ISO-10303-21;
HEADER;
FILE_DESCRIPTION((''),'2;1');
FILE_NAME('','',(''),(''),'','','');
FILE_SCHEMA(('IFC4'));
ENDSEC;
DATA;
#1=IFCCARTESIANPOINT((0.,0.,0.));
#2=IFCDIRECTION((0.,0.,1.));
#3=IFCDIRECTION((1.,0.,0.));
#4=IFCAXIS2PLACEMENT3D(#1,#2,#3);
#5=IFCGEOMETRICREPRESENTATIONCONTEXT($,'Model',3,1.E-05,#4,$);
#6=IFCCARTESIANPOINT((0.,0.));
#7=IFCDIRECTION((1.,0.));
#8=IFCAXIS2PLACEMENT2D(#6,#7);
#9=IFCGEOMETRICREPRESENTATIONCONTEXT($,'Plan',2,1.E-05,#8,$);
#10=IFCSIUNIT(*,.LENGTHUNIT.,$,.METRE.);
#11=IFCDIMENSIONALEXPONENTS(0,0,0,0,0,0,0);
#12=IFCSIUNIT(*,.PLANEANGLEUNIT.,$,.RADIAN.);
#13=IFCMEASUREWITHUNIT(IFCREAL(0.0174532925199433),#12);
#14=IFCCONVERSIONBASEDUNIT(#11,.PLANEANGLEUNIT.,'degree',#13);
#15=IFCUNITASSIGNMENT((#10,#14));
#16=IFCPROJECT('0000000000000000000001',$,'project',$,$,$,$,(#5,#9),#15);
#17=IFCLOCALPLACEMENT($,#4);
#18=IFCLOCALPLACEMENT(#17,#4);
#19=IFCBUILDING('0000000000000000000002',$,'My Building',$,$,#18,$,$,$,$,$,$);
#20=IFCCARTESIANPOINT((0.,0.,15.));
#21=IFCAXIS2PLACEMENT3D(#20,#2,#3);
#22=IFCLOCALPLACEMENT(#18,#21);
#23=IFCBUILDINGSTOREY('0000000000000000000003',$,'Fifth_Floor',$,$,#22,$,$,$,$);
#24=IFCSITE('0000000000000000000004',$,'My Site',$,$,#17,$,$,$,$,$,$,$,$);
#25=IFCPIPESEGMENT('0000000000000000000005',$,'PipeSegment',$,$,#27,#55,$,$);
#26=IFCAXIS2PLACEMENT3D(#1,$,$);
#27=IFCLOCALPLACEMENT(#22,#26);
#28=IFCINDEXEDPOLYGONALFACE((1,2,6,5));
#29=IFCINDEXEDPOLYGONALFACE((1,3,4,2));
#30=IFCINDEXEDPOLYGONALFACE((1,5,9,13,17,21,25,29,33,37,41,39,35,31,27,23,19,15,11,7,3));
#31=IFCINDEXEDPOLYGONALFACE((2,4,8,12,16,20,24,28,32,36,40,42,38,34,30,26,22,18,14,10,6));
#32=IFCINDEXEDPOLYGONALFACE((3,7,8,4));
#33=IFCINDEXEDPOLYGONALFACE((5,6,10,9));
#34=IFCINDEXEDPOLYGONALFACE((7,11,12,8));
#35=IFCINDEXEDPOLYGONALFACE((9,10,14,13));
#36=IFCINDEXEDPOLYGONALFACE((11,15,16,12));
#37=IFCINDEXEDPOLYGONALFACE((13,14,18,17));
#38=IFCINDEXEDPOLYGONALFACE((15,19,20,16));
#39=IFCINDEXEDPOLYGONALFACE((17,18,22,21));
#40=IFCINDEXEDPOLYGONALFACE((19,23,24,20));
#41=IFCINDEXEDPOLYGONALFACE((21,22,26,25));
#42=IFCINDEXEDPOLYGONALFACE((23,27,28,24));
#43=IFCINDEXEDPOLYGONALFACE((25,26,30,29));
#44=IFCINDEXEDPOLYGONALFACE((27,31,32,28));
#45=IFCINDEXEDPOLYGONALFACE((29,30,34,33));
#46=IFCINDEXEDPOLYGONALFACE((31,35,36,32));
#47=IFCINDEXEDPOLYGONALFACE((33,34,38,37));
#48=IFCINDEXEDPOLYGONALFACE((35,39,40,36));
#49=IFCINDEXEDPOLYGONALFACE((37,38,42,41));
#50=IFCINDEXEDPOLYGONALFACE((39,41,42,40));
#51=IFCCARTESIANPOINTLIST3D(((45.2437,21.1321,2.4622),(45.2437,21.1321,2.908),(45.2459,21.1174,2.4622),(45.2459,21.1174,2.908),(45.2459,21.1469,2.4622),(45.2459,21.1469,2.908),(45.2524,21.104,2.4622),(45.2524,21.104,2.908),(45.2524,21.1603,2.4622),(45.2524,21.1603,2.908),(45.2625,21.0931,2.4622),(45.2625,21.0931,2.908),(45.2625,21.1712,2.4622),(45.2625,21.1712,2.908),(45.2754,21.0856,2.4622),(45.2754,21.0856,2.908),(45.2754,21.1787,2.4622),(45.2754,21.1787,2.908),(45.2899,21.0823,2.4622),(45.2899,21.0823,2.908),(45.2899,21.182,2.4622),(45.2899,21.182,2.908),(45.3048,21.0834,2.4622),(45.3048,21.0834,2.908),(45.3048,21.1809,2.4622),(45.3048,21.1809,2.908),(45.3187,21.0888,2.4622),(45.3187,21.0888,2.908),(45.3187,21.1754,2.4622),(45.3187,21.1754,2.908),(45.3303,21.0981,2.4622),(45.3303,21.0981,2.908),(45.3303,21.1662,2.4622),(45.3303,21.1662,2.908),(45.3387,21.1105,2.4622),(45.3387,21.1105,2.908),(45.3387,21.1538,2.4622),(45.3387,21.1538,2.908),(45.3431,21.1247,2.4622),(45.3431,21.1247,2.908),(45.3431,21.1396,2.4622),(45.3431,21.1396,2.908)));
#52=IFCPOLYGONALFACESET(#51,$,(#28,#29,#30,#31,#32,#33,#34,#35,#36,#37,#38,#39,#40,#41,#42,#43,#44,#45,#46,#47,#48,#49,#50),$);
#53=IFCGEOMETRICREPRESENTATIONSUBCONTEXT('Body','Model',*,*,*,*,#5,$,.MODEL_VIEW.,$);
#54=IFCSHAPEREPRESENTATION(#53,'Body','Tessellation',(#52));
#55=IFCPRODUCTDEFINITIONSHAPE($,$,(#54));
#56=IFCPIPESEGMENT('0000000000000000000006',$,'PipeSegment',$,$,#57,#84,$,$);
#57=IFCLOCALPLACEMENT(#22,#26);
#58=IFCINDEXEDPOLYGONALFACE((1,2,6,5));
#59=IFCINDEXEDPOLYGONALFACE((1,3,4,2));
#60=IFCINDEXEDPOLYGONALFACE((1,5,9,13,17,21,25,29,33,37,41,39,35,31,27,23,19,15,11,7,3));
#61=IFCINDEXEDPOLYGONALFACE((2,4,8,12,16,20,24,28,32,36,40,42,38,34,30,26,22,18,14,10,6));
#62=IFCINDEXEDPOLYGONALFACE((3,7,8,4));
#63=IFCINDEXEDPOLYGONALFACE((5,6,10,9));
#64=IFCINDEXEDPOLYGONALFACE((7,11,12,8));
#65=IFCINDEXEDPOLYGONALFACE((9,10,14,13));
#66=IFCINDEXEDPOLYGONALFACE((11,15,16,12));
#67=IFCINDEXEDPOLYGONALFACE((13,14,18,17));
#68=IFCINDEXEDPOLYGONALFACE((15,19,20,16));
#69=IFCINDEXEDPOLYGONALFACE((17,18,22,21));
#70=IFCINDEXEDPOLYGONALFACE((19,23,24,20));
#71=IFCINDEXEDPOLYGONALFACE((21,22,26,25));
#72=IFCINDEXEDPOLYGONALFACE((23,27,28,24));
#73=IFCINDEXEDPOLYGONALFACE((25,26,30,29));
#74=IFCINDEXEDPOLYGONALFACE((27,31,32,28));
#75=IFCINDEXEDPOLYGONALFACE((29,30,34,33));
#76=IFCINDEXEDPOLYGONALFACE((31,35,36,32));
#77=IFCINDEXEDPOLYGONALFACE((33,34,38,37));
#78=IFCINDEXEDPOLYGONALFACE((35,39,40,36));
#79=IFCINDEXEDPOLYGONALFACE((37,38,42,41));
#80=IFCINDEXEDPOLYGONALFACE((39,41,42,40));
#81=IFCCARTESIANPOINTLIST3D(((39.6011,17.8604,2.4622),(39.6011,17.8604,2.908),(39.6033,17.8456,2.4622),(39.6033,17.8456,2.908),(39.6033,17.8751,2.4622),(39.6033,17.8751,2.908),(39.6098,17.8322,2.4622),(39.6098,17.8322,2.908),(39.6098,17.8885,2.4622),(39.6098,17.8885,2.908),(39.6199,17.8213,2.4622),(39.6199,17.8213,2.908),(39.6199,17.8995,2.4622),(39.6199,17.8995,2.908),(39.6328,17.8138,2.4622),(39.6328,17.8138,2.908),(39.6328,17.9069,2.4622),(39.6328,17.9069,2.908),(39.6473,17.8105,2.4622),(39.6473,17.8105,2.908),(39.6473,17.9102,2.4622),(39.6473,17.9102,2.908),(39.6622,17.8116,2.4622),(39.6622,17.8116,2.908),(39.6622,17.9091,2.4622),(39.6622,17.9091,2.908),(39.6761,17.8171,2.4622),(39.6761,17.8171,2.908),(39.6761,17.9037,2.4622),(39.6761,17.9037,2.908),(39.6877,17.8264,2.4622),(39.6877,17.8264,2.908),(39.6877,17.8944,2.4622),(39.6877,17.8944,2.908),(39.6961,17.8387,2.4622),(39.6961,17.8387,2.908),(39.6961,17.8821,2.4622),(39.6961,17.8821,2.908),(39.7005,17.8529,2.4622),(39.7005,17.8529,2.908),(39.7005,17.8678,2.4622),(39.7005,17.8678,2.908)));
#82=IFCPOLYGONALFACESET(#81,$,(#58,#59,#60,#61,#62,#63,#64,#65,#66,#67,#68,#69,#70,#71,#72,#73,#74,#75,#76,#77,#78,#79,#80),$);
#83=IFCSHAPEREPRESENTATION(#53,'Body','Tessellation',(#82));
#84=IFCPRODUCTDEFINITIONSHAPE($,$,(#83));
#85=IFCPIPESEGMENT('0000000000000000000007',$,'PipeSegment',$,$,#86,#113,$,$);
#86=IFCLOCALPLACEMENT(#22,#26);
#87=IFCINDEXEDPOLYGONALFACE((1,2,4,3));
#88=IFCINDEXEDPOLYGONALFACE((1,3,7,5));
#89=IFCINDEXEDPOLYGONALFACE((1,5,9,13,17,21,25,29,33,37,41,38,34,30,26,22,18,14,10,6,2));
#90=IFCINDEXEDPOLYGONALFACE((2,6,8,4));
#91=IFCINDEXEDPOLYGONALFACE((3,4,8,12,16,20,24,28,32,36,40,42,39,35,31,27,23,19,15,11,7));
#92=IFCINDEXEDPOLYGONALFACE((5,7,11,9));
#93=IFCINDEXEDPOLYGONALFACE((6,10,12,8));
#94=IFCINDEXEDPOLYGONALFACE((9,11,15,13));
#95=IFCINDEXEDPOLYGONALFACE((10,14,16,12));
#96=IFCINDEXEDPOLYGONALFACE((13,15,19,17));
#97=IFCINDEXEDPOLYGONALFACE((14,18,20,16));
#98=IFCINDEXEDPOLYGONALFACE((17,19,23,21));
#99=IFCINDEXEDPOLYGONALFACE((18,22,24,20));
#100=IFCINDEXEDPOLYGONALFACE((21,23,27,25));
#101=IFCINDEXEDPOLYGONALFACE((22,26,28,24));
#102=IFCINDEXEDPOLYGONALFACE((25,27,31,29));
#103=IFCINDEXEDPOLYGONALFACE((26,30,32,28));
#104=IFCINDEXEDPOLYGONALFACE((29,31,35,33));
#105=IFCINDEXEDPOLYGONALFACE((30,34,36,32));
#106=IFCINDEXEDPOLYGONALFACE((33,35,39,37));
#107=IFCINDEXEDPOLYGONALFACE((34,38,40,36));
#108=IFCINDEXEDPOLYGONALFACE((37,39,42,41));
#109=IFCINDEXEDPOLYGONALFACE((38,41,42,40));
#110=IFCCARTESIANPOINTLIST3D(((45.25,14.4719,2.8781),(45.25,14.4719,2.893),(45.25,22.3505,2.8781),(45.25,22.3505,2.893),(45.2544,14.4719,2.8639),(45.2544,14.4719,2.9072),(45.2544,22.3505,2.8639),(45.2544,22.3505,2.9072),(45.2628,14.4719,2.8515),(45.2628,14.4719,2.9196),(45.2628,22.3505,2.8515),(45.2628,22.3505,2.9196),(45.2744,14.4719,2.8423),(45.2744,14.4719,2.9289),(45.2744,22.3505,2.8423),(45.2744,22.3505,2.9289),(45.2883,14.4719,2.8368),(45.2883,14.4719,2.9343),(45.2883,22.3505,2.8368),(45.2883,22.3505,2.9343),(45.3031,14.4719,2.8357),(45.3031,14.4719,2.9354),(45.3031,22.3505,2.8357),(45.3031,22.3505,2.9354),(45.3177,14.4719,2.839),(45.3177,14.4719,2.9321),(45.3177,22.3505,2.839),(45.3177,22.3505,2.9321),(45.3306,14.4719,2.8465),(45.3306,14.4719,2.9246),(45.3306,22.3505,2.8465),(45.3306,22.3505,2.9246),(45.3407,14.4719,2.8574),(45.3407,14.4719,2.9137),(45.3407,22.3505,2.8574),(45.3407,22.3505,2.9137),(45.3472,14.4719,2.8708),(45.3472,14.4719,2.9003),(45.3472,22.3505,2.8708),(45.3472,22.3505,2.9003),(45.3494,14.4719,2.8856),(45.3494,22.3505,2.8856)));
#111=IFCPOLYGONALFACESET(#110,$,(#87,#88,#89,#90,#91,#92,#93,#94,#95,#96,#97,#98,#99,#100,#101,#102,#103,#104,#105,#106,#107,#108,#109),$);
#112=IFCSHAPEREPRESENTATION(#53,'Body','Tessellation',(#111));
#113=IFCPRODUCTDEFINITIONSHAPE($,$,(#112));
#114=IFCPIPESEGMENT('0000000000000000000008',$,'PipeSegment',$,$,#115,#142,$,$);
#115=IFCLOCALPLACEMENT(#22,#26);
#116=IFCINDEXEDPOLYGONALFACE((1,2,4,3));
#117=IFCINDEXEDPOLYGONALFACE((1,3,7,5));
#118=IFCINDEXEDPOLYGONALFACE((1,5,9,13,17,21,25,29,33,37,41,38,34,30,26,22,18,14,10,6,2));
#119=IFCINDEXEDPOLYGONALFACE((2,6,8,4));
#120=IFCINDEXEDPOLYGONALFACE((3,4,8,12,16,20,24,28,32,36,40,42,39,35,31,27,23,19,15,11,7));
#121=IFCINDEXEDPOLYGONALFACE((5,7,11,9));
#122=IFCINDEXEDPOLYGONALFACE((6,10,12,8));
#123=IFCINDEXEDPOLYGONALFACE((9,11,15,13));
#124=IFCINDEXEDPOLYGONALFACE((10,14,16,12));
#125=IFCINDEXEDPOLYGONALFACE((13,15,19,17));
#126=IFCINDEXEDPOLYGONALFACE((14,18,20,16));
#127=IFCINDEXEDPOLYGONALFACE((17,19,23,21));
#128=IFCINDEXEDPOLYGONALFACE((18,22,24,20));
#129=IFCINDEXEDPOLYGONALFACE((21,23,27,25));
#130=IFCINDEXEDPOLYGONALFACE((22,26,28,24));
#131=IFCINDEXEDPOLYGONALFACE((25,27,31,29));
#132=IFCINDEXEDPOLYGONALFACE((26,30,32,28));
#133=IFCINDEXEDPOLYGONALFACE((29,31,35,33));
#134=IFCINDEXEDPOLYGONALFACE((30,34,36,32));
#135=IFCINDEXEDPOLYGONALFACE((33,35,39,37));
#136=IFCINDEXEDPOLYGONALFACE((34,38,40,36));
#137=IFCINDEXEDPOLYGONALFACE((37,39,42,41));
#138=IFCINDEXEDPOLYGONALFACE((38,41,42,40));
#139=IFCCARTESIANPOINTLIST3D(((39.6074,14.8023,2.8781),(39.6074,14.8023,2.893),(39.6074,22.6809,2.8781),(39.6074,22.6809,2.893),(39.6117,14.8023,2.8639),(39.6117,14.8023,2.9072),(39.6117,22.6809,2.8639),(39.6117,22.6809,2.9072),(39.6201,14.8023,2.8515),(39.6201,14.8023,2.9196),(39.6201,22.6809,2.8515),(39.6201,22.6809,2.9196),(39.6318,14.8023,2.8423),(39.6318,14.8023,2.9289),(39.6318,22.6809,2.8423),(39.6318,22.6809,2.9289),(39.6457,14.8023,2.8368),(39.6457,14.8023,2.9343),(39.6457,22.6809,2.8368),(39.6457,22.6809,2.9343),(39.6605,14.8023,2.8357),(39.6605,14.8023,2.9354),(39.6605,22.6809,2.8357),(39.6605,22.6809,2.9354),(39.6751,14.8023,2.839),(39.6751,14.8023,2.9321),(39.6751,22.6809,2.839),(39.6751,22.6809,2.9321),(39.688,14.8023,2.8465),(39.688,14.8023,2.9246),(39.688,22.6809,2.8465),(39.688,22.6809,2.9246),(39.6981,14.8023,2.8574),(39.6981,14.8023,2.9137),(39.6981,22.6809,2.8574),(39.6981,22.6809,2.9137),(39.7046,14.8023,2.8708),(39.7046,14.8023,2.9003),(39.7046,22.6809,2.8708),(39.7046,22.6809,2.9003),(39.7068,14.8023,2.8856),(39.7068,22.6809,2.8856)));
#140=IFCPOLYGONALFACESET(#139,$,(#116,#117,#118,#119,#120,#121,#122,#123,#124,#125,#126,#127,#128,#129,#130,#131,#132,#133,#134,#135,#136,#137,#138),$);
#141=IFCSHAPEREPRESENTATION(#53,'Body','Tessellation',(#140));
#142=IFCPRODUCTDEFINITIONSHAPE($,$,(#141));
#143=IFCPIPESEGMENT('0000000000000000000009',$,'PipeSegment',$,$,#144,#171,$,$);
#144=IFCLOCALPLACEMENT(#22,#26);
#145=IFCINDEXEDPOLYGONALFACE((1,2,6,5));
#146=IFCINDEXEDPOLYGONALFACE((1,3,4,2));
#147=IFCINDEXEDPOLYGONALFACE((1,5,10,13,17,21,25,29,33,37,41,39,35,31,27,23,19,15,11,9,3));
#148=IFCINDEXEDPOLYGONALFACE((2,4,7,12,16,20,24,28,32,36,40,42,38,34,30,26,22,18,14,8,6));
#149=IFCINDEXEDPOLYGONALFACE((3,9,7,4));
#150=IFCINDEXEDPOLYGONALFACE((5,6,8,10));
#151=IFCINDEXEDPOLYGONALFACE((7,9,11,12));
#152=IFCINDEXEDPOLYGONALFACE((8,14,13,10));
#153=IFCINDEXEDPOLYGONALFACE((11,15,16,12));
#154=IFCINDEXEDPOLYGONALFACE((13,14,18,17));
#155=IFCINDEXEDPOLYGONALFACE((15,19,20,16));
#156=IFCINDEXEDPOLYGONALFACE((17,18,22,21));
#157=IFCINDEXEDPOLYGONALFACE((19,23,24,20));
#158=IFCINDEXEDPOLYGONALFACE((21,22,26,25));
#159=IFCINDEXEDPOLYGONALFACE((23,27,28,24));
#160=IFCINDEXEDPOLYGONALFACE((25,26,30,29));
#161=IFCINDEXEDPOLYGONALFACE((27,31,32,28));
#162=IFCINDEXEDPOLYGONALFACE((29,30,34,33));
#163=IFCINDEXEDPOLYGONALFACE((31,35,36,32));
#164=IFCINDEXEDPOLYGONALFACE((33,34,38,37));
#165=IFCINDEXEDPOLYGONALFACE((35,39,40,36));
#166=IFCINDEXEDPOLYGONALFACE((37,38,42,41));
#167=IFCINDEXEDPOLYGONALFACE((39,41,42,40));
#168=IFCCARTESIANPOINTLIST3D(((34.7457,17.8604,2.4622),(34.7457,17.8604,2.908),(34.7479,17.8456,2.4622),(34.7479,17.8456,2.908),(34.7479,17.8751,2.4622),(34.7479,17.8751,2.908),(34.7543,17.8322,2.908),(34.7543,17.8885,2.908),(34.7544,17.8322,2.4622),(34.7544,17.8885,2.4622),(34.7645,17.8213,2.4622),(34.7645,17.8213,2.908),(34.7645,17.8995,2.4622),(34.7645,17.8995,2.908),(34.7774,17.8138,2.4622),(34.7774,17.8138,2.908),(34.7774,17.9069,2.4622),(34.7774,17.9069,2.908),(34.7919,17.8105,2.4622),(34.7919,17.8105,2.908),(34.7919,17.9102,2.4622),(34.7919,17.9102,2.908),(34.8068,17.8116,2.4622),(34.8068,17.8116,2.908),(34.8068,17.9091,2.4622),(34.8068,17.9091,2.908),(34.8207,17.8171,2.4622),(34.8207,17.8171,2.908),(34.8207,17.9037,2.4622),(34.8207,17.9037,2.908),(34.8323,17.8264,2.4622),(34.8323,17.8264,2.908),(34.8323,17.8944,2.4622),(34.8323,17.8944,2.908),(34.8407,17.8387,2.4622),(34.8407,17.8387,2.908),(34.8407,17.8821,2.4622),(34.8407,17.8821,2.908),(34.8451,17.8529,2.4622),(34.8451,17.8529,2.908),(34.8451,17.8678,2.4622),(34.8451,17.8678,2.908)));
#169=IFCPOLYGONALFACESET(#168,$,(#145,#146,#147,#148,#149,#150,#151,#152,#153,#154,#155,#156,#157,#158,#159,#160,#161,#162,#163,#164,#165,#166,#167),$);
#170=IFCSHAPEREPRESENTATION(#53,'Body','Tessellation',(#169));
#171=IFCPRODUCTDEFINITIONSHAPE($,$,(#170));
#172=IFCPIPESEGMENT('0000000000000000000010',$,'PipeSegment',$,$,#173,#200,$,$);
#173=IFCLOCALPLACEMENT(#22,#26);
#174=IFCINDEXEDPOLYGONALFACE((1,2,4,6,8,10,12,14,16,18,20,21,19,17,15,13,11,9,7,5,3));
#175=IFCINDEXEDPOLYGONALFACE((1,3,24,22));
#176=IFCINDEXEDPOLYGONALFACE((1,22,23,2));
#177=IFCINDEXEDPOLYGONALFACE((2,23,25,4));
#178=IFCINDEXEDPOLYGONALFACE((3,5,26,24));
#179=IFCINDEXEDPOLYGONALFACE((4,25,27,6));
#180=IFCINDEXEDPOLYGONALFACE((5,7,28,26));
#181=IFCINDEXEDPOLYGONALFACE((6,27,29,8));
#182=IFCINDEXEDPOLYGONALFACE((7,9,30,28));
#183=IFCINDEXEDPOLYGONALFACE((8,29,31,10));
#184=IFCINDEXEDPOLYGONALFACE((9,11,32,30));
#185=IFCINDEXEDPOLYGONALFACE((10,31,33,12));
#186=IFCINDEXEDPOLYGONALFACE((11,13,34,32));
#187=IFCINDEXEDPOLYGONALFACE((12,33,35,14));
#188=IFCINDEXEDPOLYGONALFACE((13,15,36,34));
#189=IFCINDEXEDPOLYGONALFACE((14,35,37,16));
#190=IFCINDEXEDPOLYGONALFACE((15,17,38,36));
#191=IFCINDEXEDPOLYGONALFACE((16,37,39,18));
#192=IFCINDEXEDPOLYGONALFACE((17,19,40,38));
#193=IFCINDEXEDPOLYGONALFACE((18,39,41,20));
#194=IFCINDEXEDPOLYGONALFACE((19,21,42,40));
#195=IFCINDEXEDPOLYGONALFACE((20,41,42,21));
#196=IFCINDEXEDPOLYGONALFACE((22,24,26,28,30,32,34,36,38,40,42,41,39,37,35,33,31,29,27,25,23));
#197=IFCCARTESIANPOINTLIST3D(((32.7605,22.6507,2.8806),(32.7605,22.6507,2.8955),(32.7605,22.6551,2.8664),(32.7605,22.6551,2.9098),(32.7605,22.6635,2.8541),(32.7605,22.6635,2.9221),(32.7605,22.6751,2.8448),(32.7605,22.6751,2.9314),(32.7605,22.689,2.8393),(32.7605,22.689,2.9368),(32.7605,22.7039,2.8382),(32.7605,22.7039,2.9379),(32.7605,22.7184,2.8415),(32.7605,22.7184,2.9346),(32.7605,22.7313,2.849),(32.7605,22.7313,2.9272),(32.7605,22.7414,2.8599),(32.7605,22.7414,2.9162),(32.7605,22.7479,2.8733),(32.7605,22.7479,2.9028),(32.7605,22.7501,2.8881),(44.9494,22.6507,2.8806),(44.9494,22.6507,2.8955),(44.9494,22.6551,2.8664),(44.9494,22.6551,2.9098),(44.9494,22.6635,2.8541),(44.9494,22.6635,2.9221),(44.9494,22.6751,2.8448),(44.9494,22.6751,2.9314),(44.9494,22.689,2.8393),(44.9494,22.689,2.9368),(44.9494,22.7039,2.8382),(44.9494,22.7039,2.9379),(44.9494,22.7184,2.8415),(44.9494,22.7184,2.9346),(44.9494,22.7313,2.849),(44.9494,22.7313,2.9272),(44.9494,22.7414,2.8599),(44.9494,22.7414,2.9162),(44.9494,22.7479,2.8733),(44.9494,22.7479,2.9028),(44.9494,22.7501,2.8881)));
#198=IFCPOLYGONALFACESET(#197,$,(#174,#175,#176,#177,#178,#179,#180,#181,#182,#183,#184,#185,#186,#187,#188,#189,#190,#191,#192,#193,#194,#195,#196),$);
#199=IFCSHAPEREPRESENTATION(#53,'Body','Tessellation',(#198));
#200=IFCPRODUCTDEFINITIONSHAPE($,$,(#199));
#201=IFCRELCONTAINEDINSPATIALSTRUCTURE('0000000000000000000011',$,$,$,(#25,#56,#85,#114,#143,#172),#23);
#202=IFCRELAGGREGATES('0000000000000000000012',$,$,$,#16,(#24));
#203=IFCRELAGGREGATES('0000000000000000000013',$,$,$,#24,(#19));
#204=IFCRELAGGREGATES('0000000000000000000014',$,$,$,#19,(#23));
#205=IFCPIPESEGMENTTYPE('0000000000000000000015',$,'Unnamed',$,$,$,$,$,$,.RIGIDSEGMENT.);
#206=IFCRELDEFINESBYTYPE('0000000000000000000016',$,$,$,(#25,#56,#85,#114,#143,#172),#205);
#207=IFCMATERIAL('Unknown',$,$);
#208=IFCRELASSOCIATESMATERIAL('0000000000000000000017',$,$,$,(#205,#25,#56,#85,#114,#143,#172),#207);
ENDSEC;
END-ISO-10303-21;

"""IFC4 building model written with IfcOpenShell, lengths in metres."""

from ifc_helpers import new_model, entity, si_unit, converted_unit, frame, origin_with_axes, origin_2d_with_axis, place, context, subcontext, project, spatial, circle, extrude, material, material_profile, profile_set, profile_usage, type_object, element, save


model = new_model("IFC4")

# Units and contexts
model_context = context("Model", 3, precision=1e-05, world=origin_with_axes())
plan_context = context("Plan", 2, precision=1e-05, world=origin_2d_with_axis())
body_context_1 = subcontext(model_context, "Body", "Model", "MODEL_VIEW")
ifc_project = project(units=[si_unit("LENGTHUNIT", "METRE"), converted_unit("PLANEANGLEUNIT", "degree", entity("IfcReal", 0.0174532925199433), si_unit("PLANEANGLEUNIT", "RADIAN"), dimensions=[0, 0, 0, 0, 0, 0, 0])], contexts=[model_context, plan_context])

# Site, building, storey
site_placement = place(None, origin_with_axes())
site = spatial("IfcSite", under=ifc_project, at=site_placement, Name="My Site")
building_placement = place(site_placement, origin_with_axes())
building = spatial("IfcBuilding", under=site, at=building_placement, Name="My Building")
storey_placement = place(building_placement, frame((0.0, 0.0, 15.0), z_axis=(0.0, 0.0, 1.0), x_axis=(1.0, 0.0, 0.0)))
storey = spatial("IfcBuildingStorey", under=building, at=storey_placement, Name="Fifth_Floor")

# Shared definitions
ifc_material = material(Name="Unknown")

# Pipe segments
ifc_material_profile_1 = material_profile(ifc_material, circle(Radius=0.05))
ifc_profile_set_1 = profile_set([ifc_material_profile_1])
pipe_segment_type = type_object("IfcPipeSegmentType", Name="Unnamed", PredefinedType="RIGIDSEGMENT", material=ifc_profile_set_1)
ifc_profile_usage_1 = profile_usage(ifc_profile_set_1, cardinal=5)
pipe_segment_1_placement = place(storey_placement, frame((45.2937, 21.1321, 2.908), z_axis=(0.0, 0.0, -1.0), x_axis=(-1.0, 0.0, 0.0)))
element("IfcPipeSegment", 1, at=pipe_segment_1_placement, inside=storey, type_object=pipe_segment_type, material=ifc_profile_usage_1, Name="PipeSegment", context=body_context_1, shape_type="SweptSolid", body=[
    extrude(circle(Radius=0.05), origin_with_axes(), (0.0, 0.0, 1.0), 0.4458),
])
ifc_profile_usage_2 = profile_usage(ifc_profile_set_1, cardinal=5)
pipe_segment_2_placement = place(storey_placement, frame((39.6511, 17.8604, 2.908), z_axis=(0.0, 0.0, -1.0), x_axis=(-1.0, 0.0, 0.0)))
element("IfcPipeSegment", 2, at=pipe_segment_2_placement, inside=storey, type_object=pipe_segment_type, material=ifc_profile_usage_2, Name="PipeSegment", context=body_context_1, shape_type="SweptSolid", body=[
    extrude(circle(Radius=0.05), origin_with_axes(), (0.0, 0.0, 1.0), 0.4458),
])
ifc_profile_usage_3 = profile_usage(ifc_profile_set_1, cardinal=5)
pipe_segment_3_placement = place(storey_placement, frame((45.2994, 22.3505, 2.8856), z_axis=(0.0, -1.0, 0.0), x_axis=(1.0, 0.0, 0.0)))
element("IfcPipeSegment", 3, at=pipe_segment_3_placement, inside=storey, type_object=pipe_segment_type, material=ifc_profile_usage_3, Name="PipeSegment", context=body_context_1, shape_type="SweptSolid", body=[
    extrude(circle(Radius=0.05), origin_with_axes(), (0.0, 0.0, 1.0), 7.8786),
])
ifc_profile_usage_4 = profile_usage(ifc_profile_set_1, cardinal=5)
pipe_segment_4_placement = place(storey_placement, frame((39.6568, 22.6809, 2.8856), z_axis=(0.0, -1.0, 0.0), x_axis=(1.0, 0.0, 0.0)))
element("IfcPipeSegment", 4, at=pipe_segment_4_placement, inside=storey, type_object=pipe_segment_type, material=ifc_profile_usage_4, Name="PipeSegment", context=body_context_1, shape_type="SweptSolid", body=[
    extrude(circle(Radius=0.05), origin_with_axes(), (0.0, 0.0, 1.0), 7.8786),
])
ifc_profile_usage_5 = profile_usage(ifc_profile_set_1, cardinal=5)
pipe_segment_5_placement = place(storey_placement, frame((34.7957, 17.8604, 2.908), z_axis=(0.0, 0.0, -1.0), x_axis=(-1.0, 0.0, 0.0)))
element("IfcPipeSegment", 5, at=pipe_segment_5_placement, inside=storey, type_object=pipe_segment_type, material=ifc_profile_usage_5, Name="PipeSegment", context=body_context_1, shape_type="SweptSolid", body=[
    extrude(circle(Radius=0.05), origin_with_axes(), (0.0, 0.0, 1.0), 0.4458),
])
ifc_profile_usage_6 = profile_usage(ifc_profile_set_1, cardinal=6)
pipe_segment_6_placement = place(storey_placement, frame((32.7605, 22.6501, 2.8881), z_axis=(1.0, 0.0, 0.000001), x_axis=(0.0, 1.0, 0.0)))
element("IfcPipeSegment", 6, at=pipe_segment_6_placement, inside=storey, type_object=pipe_segment_type, material=ifc_profile_usage_6, Name="PipeSegment", context=body_context_1, shape_type="SweptSolid", body=[
    extrude(circle(Radius=0.05), frame((0.05, 0.0, 0.0), z_axis=(0.0, 0.0, 1.0), x_axis=(1.0, 0.0, 0.0)), (0.0, 0.0, 1.0), 12.1889),
])

save(model, "model.ifc")
